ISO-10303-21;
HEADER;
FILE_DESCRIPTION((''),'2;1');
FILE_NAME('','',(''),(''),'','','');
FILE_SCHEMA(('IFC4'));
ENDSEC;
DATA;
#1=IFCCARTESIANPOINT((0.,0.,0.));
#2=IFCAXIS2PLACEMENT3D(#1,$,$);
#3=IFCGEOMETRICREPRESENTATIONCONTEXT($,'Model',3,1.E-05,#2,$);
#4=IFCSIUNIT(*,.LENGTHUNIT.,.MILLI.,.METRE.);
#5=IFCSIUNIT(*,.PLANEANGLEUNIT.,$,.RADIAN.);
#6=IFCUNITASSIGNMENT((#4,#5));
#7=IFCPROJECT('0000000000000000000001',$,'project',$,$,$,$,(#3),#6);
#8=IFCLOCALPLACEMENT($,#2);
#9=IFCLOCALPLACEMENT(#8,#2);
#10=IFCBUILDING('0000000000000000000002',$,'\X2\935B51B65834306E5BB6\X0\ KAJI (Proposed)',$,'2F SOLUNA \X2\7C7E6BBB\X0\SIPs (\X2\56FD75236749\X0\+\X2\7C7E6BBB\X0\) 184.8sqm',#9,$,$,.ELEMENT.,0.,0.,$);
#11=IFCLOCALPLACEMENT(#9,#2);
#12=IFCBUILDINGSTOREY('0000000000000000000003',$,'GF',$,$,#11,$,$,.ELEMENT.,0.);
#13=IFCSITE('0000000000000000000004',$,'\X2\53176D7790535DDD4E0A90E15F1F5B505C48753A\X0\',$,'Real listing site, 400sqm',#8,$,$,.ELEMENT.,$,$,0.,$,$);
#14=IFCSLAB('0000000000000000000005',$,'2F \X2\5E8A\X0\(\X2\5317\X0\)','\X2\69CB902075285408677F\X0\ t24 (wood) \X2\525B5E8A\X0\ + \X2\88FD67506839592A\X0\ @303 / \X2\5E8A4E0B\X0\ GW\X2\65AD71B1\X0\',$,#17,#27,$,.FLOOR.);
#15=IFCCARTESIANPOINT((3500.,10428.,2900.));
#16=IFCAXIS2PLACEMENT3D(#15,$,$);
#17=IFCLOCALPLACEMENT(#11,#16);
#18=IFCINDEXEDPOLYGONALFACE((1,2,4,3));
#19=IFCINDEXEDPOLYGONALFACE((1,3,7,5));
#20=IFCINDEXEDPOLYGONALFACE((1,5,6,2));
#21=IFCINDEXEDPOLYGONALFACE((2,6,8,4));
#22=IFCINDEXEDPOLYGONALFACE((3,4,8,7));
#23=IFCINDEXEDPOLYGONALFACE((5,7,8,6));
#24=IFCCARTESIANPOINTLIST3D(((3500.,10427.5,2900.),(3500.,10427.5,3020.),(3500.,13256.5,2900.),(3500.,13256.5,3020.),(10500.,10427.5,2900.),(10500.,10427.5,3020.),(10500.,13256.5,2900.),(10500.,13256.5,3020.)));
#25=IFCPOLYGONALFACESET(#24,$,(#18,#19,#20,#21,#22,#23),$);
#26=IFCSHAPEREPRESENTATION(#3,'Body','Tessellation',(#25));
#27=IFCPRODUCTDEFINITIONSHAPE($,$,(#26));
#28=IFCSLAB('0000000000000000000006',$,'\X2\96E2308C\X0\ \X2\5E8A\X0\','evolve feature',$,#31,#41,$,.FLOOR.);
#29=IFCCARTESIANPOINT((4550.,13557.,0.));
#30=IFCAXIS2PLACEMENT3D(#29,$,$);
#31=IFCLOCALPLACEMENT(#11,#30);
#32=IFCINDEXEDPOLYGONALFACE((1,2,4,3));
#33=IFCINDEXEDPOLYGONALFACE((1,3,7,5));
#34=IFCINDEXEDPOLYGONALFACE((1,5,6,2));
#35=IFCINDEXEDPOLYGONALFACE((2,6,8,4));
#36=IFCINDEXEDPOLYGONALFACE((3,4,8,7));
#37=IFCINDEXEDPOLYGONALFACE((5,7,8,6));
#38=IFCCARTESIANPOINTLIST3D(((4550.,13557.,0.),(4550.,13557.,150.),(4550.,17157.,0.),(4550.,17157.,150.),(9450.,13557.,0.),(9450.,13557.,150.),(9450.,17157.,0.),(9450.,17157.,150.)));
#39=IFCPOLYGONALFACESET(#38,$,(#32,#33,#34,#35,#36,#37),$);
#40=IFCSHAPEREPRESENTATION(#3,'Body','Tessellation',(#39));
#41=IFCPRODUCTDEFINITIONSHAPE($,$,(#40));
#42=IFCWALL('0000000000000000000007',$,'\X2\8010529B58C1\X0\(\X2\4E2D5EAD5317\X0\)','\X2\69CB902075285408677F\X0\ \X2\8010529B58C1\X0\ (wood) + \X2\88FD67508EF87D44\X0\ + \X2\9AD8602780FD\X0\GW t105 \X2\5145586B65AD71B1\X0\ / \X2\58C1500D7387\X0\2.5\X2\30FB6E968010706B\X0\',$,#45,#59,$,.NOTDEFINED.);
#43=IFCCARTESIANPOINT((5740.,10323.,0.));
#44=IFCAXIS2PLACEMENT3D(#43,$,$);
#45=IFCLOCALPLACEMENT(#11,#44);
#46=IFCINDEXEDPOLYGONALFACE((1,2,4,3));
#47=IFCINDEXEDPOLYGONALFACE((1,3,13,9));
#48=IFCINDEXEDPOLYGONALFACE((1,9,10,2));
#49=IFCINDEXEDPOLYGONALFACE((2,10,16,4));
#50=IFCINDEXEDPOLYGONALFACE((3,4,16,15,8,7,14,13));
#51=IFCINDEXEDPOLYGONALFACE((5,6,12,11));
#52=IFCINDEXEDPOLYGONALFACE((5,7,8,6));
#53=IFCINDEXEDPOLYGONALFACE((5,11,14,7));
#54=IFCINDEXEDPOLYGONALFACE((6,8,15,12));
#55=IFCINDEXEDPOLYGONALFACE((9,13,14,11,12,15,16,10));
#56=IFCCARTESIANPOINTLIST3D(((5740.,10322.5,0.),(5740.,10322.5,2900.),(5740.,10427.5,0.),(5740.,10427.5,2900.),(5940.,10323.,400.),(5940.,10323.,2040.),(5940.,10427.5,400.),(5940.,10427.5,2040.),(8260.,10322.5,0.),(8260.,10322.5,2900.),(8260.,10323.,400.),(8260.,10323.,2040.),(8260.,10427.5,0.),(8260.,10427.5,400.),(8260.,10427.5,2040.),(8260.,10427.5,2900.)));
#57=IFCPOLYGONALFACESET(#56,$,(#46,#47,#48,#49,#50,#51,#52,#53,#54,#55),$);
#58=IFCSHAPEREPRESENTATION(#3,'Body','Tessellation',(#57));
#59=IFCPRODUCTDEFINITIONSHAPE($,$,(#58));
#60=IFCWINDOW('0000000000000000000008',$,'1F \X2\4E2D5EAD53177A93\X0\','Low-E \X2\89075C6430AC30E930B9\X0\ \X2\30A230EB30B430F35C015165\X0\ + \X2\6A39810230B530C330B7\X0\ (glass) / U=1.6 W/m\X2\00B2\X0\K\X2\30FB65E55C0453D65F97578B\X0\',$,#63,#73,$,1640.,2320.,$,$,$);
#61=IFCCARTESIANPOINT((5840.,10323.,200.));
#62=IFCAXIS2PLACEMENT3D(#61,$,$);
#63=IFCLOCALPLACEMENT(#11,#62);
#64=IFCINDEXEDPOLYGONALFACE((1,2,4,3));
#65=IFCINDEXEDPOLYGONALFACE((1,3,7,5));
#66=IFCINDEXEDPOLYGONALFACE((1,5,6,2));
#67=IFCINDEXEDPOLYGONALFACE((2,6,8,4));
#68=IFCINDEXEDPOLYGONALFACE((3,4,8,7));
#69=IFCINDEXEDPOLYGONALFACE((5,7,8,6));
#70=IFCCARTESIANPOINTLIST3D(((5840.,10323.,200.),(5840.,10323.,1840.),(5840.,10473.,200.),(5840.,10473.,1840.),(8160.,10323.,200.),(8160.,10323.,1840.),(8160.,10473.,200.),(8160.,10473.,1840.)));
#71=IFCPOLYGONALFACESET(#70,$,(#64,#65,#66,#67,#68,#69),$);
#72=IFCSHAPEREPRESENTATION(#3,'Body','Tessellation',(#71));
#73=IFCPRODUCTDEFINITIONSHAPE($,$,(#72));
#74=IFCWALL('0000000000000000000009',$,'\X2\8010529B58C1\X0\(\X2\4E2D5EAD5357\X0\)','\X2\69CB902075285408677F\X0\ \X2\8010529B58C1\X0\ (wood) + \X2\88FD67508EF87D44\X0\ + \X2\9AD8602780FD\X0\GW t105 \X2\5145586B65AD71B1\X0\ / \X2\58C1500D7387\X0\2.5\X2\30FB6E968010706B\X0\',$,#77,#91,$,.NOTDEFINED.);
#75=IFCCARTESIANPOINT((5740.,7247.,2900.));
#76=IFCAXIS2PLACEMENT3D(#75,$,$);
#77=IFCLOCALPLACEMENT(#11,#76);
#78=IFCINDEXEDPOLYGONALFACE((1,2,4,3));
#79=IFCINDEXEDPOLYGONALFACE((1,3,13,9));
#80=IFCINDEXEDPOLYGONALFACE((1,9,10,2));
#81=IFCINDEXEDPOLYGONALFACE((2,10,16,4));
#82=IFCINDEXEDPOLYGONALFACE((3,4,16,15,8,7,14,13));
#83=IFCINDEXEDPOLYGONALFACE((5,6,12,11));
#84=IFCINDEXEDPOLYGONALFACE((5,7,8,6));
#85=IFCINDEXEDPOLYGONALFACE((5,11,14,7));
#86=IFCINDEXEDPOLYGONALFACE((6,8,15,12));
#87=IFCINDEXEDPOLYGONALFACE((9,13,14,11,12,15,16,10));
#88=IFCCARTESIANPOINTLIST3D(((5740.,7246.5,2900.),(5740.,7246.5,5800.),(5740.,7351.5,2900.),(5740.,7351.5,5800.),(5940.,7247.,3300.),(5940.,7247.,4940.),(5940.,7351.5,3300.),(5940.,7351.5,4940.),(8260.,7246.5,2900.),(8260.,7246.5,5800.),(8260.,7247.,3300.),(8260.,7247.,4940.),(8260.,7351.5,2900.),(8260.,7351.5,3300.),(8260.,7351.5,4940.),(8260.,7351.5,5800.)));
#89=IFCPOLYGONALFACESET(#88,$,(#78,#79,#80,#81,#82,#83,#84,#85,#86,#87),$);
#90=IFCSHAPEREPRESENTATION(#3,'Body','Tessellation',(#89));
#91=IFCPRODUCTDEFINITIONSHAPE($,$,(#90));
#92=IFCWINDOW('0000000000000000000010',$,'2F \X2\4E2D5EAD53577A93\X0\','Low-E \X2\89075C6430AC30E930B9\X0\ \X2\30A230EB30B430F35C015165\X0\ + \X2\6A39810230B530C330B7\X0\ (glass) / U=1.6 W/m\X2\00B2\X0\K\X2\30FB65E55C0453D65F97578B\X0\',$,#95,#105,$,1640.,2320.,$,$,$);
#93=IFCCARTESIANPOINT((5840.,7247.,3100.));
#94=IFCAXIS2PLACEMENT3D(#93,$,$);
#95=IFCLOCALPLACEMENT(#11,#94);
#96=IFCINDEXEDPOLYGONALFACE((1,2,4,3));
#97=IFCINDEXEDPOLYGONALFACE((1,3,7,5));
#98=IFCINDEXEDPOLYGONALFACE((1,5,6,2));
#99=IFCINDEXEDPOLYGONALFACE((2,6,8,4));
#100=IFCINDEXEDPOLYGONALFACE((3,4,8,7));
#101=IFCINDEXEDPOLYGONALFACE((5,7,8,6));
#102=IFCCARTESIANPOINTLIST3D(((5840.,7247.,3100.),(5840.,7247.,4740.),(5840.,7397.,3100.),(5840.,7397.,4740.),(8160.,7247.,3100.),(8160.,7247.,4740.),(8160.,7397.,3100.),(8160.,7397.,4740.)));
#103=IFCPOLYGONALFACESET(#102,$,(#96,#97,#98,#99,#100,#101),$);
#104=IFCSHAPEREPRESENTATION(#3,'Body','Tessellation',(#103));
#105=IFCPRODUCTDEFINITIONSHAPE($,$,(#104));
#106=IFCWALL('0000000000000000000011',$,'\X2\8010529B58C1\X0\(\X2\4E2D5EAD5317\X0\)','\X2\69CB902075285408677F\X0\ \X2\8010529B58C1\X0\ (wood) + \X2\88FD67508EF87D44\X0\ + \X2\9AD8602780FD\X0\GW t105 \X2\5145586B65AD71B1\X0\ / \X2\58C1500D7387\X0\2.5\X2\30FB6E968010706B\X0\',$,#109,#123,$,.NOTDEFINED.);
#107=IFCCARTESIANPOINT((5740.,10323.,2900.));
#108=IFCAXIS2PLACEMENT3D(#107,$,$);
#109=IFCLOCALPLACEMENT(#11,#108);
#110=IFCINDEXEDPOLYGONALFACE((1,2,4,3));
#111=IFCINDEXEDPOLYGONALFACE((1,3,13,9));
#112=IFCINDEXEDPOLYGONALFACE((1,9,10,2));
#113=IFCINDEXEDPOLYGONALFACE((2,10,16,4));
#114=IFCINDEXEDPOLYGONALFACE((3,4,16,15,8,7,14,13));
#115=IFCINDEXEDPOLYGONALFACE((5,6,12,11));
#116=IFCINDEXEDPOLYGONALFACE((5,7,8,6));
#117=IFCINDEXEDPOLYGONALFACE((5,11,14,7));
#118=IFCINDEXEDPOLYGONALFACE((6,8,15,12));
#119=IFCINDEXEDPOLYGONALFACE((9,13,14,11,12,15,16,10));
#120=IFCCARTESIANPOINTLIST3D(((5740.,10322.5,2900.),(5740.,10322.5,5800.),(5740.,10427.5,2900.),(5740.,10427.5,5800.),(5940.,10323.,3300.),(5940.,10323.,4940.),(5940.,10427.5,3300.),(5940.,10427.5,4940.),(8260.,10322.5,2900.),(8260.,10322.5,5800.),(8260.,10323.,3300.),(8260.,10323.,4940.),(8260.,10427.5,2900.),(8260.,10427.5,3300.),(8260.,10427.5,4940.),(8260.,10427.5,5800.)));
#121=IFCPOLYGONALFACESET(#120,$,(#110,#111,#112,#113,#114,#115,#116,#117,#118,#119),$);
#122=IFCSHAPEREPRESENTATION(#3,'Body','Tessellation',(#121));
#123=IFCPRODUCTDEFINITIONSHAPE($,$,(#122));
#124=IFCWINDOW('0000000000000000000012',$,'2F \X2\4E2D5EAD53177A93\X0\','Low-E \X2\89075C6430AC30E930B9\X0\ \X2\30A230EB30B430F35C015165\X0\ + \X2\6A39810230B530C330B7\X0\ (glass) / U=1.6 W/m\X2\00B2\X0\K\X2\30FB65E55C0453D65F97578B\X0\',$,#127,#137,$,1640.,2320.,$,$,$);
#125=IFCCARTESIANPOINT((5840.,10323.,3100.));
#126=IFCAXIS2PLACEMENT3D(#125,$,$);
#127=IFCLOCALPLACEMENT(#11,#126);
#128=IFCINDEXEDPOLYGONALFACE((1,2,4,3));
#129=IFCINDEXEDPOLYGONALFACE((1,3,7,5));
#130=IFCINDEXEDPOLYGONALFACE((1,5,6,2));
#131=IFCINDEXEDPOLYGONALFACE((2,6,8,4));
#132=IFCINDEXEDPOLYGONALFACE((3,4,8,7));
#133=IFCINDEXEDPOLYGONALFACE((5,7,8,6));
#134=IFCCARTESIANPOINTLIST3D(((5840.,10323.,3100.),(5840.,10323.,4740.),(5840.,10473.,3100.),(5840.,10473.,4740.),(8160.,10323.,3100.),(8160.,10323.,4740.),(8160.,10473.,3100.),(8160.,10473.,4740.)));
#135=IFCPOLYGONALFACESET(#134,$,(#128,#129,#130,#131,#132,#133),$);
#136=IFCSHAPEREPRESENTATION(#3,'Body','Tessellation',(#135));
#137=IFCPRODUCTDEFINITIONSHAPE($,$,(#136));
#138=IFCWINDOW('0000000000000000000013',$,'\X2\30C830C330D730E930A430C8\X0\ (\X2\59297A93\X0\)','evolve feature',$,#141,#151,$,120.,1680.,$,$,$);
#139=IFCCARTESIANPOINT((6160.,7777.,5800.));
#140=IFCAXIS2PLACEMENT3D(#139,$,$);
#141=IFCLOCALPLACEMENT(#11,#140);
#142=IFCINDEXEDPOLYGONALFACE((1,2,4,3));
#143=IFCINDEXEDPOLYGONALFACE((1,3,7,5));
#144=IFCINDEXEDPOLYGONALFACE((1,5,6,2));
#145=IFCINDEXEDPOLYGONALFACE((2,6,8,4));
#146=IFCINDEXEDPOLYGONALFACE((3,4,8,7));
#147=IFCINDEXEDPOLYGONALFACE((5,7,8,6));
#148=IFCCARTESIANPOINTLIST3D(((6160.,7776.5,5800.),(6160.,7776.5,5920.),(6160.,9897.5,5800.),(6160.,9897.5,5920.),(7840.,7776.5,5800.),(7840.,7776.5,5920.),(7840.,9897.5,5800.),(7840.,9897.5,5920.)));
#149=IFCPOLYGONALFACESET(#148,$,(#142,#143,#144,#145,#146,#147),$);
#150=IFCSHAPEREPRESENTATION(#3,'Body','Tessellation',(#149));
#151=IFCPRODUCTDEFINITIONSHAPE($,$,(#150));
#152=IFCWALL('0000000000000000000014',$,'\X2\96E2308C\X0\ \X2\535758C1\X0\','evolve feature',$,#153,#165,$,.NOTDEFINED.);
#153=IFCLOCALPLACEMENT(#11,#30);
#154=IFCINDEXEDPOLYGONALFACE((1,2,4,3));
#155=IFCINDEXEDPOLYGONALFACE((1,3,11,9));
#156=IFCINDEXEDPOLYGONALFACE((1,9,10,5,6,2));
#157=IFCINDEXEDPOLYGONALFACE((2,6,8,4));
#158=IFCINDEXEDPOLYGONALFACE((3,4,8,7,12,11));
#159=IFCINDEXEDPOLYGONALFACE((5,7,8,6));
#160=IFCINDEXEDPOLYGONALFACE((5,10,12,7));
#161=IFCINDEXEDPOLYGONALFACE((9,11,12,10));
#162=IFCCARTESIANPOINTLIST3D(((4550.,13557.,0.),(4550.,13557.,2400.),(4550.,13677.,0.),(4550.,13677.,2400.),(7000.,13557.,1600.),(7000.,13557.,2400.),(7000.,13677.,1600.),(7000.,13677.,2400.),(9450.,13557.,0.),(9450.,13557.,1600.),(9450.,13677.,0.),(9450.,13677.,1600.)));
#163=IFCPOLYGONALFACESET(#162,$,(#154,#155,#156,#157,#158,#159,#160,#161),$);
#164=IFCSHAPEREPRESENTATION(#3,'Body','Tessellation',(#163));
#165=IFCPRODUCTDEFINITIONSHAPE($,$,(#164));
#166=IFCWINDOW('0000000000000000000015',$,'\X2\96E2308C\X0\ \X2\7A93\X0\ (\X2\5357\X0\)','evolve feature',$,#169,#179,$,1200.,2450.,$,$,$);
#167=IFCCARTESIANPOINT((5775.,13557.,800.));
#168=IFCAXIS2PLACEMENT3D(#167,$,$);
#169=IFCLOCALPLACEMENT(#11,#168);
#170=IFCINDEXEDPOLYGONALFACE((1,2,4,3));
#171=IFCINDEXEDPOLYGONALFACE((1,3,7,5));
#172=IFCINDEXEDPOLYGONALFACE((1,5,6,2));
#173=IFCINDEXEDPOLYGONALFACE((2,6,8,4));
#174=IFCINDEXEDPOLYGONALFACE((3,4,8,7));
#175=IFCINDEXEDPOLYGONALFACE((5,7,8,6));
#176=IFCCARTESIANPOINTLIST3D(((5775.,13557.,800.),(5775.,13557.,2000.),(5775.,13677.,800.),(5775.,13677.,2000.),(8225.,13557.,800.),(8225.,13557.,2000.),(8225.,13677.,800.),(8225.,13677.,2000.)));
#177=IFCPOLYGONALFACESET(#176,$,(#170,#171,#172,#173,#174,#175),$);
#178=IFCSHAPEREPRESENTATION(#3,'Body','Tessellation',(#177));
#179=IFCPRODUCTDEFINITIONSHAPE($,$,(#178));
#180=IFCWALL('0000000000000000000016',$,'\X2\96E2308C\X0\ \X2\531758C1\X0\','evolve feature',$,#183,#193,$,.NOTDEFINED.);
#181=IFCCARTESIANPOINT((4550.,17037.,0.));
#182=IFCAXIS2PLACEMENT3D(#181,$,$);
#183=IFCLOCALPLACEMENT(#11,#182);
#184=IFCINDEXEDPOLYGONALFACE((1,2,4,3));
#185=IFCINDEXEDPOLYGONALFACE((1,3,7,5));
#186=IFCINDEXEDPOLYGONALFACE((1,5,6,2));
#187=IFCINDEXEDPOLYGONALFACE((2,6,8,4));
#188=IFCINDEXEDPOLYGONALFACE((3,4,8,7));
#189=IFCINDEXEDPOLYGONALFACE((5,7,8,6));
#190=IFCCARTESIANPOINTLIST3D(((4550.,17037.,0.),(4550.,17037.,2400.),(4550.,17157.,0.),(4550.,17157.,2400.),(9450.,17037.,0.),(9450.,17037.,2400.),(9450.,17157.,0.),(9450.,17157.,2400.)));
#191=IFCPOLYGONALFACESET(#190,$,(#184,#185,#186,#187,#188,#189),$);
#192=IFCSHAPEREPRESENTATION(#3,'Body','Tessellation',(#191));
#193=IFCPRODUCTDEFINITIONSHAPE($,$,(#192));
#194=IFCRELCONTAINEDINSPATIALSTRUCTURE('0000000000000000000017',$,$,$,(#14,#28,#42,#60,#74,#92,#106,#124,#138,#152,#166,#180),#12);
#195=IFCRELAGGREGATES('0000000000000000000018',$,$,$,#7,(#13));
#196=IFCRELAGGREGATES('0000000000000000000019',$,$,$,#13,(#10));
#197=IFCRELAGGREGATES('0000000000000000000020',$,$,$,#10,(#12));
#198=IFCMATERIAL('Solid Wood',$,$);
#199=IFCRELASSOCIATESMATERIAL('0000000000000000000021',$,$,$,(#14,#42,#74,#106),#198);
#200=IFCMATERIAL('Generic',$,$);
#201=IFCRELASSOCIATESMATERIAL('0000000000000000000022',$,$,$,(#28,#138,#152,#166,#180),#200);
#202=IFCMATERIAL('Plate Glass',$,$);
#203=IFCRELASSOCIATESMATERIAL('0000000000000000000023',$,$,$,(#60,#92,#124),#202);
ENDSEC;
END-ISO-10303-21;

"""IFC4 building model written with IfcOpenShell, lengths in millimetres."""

from ifc_helpers import new_model, si_unit, frame, frame_2d, origin, place, context, project, spatial, rectangle, extrude, material, element, fill, save


model = new_model("IFC4")

# Units and contexts
model_context = context("Model", 3, precision=1e-05, world=origin())
ifc_project = project(units=[si_unit("LENGTHUNIT", "METRE", prefix="MILLI"), si_unit("PLANEANGLEUNIT", "RADIAN")], contexts=[model_context])

# Site, building, storey
site_placement = place(None, origin())
site = spatial("IfcSite", under=ifc_project, at=site_placement, Name="北海道川上郡弟子屈町", ObjectType="Real listing site, 400sqm", CompositionType="ELEMENT", RefElevation=0.0)
building_placement = place(site_placement, origin())
building = spatial("IfcBuilding", under=site, at=building_placement, Name="鍛冶場の家 KAJI (Proposed)", ObjectType="2F SOLUNA 籾殻SIPs (国産杉+籾殻) 184.8sqm", CompositionType="ELEMENT", ElevationOfRefHeight=0.0, ElevationOfTerrain=0.0)
storey_placement = place(building_placement, origin())
storey = spatial("IfcBuildingStorey", under=building, at=storey_placement, Name="GF", CompositionType="ELEMENT", Elevation=0.0)

# Slabs
ifc_material_1 = material(Name="Solid Wood")
slab_1_placement = place(storey_placement, frame((3500.0, 10428.0, 2900.0)))
element("IfcSlab", 1, at=slab_1_placement, inside=storey, material=ifc_material_1, Name="2F 床(北)", Description="構造用合板 t24 (wood) 剛床 + 製材根太 @303 / 床下 GW断熱", PredefinedType="FLOOR", context=model_context, shape_type="SweptSolid", body=[
    extrude(rectangle(XDim=7000.0, YDim=2829.0, at=frame_2d((3500.0, 1414.0))), frame((3500.0, 10428.0, 2900.0)), (0.0, 0.0, 1.0), 120.0),
])
ifc_material_2 = material(Name="Generic")
slab_2_placement = place(storey_placement, frame((4550.0, 13557.0, 0.0)))
element("IfcSlab", 2, at=slab_2_placement, inside=storey, material=ifc_material_2, Name="離れ 床", Description="evolve feature", PredefinedType="FLOOR", context=model_context, shape_type="SweptSolid", body=[
    extrude(rectangle(XDim=4900.0, YDim=3600.0, at=frame_2d((2450.0, 1800.0))), frame((4550.0, 13557.0, 0.0)), (0.0, 0.0, 1.0), 150.0),
])

# Wall, opening, window
wall_1_placement = place(storey_placement, frame((5740.0, 10323.0, 0.0)))
wall_1 = element("IfcWall", 3, at=wall_1_placement, inside=storey, material=ifc_material_1, Name="耐力壁(中庭北)", Description="構造用合板 耐力壁 (wood) + 製材軸組 + 高性能GW t105 充填断熱 / 壁倍率2.5・準耐火", PredefinedType="NOTDEFINED", context=model_context, shape_type="SweptSolid", body=[
    extrude(rectangle(XDim=2520.0, YDim=105.0, at=frame_2d((1260.0, 52.0))), frame((5740.0, 10323.0, 0.0)), (0.0, 0.0, 1.0), 2900.0),
])
opening_1_placement = place(storey_placement, frame((5840.0, 10323.0, 200.0)))
opening_1 = element("IfcOpeningElement", 4, at=opening_1_placement, cuts=wall_1, PredefinedType="NOTDEFINED", context=model_context, shape_type="SweptSolid", body=[
    extrude(rectangle(XDim=2320.0, YDim=150.0, at=frame_2d((1160.0, 75.0))), frame((5840.0, 10323.0, 200.0)), (0.0, 0.0, 1.0), 1640.0),
])
ifc_material_3 = material(Name="Plate Glass")
window_1_placement = place(storey_placement, frame((5840.0, 10323.0, 200.0)))
window_1 = element("IfcWindow", 5, at=window_1_placement, inside=storey, material=ifc_material_3, Name="1F 中庭北窓", Description="Low-E 複層ガラス アルゴン封入 + 樹脂サッシ (glass) / U=1.6 W/m²K・日射取得型", OverallHeight=1640.0, OverallWidth=2320.0, context=model_context, shape_type="SweptSolid", body=[
    extrude(rectangle(XDim=2320.0, YDim=150.0, at=frame_2d((1160.0, 75.0))), frame((5840.0, 10323.0, 200.0)), (0.0, 0.0, 1.0), 1640.0),
])
fill(opening_1, window_1)

# Walls, openings, windows
wall_2_placement = place(storey_placement, frame((5740.0, 7247.0, 2900.0)))
wall_2 = element("IfcWall", 6, at=wall_2_placement, inside=storey, material=ifc_material_1, Name="耐力壁(中庭南)", Description="構造用合板 耐力壁 (wood) + 製材軸組 + 高性能GW t105 充填断熱 / 壁倍率2.5・準耐火", PredefinedType="NOTDEFINED", context=model_context, shape_type="SweptSolid", body=[
    extrude(rectangle(XDim=2520.0, YDim=105.0, at=frame_2d((1260.0, 52.0))), frame((5740.0, 7247.0, 2900.0)), (0.0, 0.0, 1.0), 2900.0),
])
opening_2_placement = place(storey_placement, frame((5840.0, 7247.0, 3100.0)))
opening_2 = element("IfcOpeningElement", 7, at=opening_2_placement, cuts=wall_2, PredefinedType="NOTDEFINED", context=model_context, shape_type="SweptSolid", body=[
    extrude(rectangle(XDim=2320.0, YDim=150.0, at=frame_2d((1160.0, 75.0))), frame((5840.0, 7247.0, 3100.0)), (0.0, 0.0, 1.0), 1640.0),
])
window_2_placement = place(storey_placement, frame((5840.0, 7247.0, 3100.0)))
window_2 = element("IfcWindow", 8, at=window_2_placement, inside=storey, material=ifc_material_3, Name="2F 中庭南窓", Description="Low-E 複層ガラス アルゴン封入 + 樹脂サッシ (glass) / U=1.6 W/m²K・日射取得型", OverallHeight=1640.0, OverallWidth=2320.0, context=model_context, shape_type="SweptSolid", body=[
    extrude(rectangle(XDim=2320.0, YDim=150.0, at=frame_2d((1160.0, 75.0))), frame((5840.0, 7247.0, 3100.0)), (0.0, 0.0, 1.0), 1640.0),
])
fill(opening_2, window_2)
wall_3_placement = place(storey_placement, frame((5740.0, 10323.0, 2900.0)))
wall_3 = element("IfcWall", 9, at=wall_3_placement, inside=storey, material=ifc_material_1, Name="耐力壁(中庭北)", Description="構造用合板 耐力壁 (wood) + 製材軸組 + 高性能GW t105 充填断熱 / 壁倍率2.5・準耐火", PredefinedType="NOTDEFINED", context=model_context, shape_type="SweptSolid", body=[
    extrude(rectangle(XDim=2520.0, YDim=105.0, at=frame_2d((1260.0, 52.0))), frame((5740.0, 10323.0, 2900.0)), (0.0, 0.0, 1.0), 2900.0),
])
opening_3_placement = place(storey_placement, frame((5840.0, 10323.0, 3100.0)))
opening_3 = element("IfcOpeningElement", 10, at=opening_3_placement, cuts=wall_3, PredefinedType="NOTDEFINED", context=model_context, shape_type="SweptSolid", body=[
    extrude(rectangle(XDim=2320.0, YDim=150.0, at=frame_2d((1160.0, 75.0))), frame((5840.0, 10323.0, 3100.0)), (0.0, 0.0, 1.0), 1640.0),
])
window_3_placement = place(storey_placement, frame((5840.0, 10323.0, 3100.0)))
window_3 = element("IfcWindow", 11, at=window_3_placement, inside=storey, material=ifc_material_3, Name="2F 中庭北窓", Description="Low-E 複層ガラス アルゴン封入 + 樹脂サッシ (glass) / U=1.6 W/m²K・日射取得型", OverallHeight=1640.0, OverallWidth=2320.0, context=model_context, shape_type="SweptSolid", body=[
    extrude(rectangle(XDim=2320.0, YDim=150.0, at=frame_2d((1160.0, 75.0))), frame((5840.0, 10323.0, 3100.0)), (0.0, 0.0, 1.0), 1640.0),
])
fill(opening_3, window_3)

# Window
window_4_placement = place(storey_placement, frame((6160.0, 7777.0, 5800.0)))
element("IfcWindow", 12, at=window_4_placement, inside=storey, material=ifc_material_2, Name="トップライト (天窓)", Description="evolve feature", OverallHeight=120.0, OverallWidth=1680.0, context=model_context, shape_type="SweptSolid", body=[
    extrude(rectangle(XDim=1680.0, YDim=2121.0, at=frame_2d((840.0, 1060.0))), frame((6160.0, 7777.0, 5800.0)), (0.0, 0.0, 1.0), 120.0),
])

# Wall, opening, window
wall_4_placement = place(storey_placement, frame((4550.0, 13557.0, 0.0)))
wall_4 = element("IfcWall", 13, at=wall_4_placement, inside=storey, material=ifc_material_2, Name="離れ 南壁", Description="evolve feature", PredefinedType="NOTDEFINED", context=model_context, shape_type="SweptSolid", body=[
    extrude(rectangle(XDim=4900.0, YDim=120.0, at=frame_2d((2450.0, 60.0))), frame((4550.0, 13557.0, 0.0)), (0.0, 0.0, 1.0), 2400.0),
])
opening_4_placement = place(storey_placement, frame((5775.0, 13557.0, 800.0)))
opening_4 = element("IfcOpeningElement", 14, at=opening_4_placement, cuts=wall_4, PredefinedType="NOTDEFINED", context=model_context, shape_type="SweptSolid", body=[
    extrude(rectangle(XDim=2450.0, YDim=120.0, at=frame_2d((1225.0, 60.0))), frame((5775.0, 13557.0, 800.0)), (0.0, 0.0, 1.0), 1200.0),
])
window_5_placement = place(storey_placement, frame((5775.0, 13557.0, 800.0)))
window_5 = element("IfcWindow", 15, at=window_5_placement, inside=storey, material=ifc_material_2, Name="離れ 窓 (南)", Description="evolve feature", OverallHeight=1200.0, OverallWidth=2450.0, context=model_context, shape_type="SweptSolid", body=[
    extrude(rectangle(XDim=2450.0, YDim=120.0, at=frame_2d((1225.0, 60.0))), frame((5775.0, 13557.0, 800.0)), (0.0, 0.0, 1.0), 1200.0),
])
fill(opening_4, window_5)

# Wall
wall_5_placement = place(storey_placement, frame((4550.0, 17037.0, 0.0)))
element("IfcWall", 16, at=wall_5_placement, inside=storey, material=ifc_material_2, Name="離れ 北壁", Description="evolve feature", PredefinedType="NOTDEFINED", context=model_context, shape_type="SweptSolid", body=[
    extrude(rectangle(XDim=4900.0, YDim=120.0, at=frame_2d((2450.0, 60.0))), frame((4550.0, 17037.0, 0.0)), (0.0, 0.0, 1.0), 2400.0),
])

save(model, "model.ifc")
